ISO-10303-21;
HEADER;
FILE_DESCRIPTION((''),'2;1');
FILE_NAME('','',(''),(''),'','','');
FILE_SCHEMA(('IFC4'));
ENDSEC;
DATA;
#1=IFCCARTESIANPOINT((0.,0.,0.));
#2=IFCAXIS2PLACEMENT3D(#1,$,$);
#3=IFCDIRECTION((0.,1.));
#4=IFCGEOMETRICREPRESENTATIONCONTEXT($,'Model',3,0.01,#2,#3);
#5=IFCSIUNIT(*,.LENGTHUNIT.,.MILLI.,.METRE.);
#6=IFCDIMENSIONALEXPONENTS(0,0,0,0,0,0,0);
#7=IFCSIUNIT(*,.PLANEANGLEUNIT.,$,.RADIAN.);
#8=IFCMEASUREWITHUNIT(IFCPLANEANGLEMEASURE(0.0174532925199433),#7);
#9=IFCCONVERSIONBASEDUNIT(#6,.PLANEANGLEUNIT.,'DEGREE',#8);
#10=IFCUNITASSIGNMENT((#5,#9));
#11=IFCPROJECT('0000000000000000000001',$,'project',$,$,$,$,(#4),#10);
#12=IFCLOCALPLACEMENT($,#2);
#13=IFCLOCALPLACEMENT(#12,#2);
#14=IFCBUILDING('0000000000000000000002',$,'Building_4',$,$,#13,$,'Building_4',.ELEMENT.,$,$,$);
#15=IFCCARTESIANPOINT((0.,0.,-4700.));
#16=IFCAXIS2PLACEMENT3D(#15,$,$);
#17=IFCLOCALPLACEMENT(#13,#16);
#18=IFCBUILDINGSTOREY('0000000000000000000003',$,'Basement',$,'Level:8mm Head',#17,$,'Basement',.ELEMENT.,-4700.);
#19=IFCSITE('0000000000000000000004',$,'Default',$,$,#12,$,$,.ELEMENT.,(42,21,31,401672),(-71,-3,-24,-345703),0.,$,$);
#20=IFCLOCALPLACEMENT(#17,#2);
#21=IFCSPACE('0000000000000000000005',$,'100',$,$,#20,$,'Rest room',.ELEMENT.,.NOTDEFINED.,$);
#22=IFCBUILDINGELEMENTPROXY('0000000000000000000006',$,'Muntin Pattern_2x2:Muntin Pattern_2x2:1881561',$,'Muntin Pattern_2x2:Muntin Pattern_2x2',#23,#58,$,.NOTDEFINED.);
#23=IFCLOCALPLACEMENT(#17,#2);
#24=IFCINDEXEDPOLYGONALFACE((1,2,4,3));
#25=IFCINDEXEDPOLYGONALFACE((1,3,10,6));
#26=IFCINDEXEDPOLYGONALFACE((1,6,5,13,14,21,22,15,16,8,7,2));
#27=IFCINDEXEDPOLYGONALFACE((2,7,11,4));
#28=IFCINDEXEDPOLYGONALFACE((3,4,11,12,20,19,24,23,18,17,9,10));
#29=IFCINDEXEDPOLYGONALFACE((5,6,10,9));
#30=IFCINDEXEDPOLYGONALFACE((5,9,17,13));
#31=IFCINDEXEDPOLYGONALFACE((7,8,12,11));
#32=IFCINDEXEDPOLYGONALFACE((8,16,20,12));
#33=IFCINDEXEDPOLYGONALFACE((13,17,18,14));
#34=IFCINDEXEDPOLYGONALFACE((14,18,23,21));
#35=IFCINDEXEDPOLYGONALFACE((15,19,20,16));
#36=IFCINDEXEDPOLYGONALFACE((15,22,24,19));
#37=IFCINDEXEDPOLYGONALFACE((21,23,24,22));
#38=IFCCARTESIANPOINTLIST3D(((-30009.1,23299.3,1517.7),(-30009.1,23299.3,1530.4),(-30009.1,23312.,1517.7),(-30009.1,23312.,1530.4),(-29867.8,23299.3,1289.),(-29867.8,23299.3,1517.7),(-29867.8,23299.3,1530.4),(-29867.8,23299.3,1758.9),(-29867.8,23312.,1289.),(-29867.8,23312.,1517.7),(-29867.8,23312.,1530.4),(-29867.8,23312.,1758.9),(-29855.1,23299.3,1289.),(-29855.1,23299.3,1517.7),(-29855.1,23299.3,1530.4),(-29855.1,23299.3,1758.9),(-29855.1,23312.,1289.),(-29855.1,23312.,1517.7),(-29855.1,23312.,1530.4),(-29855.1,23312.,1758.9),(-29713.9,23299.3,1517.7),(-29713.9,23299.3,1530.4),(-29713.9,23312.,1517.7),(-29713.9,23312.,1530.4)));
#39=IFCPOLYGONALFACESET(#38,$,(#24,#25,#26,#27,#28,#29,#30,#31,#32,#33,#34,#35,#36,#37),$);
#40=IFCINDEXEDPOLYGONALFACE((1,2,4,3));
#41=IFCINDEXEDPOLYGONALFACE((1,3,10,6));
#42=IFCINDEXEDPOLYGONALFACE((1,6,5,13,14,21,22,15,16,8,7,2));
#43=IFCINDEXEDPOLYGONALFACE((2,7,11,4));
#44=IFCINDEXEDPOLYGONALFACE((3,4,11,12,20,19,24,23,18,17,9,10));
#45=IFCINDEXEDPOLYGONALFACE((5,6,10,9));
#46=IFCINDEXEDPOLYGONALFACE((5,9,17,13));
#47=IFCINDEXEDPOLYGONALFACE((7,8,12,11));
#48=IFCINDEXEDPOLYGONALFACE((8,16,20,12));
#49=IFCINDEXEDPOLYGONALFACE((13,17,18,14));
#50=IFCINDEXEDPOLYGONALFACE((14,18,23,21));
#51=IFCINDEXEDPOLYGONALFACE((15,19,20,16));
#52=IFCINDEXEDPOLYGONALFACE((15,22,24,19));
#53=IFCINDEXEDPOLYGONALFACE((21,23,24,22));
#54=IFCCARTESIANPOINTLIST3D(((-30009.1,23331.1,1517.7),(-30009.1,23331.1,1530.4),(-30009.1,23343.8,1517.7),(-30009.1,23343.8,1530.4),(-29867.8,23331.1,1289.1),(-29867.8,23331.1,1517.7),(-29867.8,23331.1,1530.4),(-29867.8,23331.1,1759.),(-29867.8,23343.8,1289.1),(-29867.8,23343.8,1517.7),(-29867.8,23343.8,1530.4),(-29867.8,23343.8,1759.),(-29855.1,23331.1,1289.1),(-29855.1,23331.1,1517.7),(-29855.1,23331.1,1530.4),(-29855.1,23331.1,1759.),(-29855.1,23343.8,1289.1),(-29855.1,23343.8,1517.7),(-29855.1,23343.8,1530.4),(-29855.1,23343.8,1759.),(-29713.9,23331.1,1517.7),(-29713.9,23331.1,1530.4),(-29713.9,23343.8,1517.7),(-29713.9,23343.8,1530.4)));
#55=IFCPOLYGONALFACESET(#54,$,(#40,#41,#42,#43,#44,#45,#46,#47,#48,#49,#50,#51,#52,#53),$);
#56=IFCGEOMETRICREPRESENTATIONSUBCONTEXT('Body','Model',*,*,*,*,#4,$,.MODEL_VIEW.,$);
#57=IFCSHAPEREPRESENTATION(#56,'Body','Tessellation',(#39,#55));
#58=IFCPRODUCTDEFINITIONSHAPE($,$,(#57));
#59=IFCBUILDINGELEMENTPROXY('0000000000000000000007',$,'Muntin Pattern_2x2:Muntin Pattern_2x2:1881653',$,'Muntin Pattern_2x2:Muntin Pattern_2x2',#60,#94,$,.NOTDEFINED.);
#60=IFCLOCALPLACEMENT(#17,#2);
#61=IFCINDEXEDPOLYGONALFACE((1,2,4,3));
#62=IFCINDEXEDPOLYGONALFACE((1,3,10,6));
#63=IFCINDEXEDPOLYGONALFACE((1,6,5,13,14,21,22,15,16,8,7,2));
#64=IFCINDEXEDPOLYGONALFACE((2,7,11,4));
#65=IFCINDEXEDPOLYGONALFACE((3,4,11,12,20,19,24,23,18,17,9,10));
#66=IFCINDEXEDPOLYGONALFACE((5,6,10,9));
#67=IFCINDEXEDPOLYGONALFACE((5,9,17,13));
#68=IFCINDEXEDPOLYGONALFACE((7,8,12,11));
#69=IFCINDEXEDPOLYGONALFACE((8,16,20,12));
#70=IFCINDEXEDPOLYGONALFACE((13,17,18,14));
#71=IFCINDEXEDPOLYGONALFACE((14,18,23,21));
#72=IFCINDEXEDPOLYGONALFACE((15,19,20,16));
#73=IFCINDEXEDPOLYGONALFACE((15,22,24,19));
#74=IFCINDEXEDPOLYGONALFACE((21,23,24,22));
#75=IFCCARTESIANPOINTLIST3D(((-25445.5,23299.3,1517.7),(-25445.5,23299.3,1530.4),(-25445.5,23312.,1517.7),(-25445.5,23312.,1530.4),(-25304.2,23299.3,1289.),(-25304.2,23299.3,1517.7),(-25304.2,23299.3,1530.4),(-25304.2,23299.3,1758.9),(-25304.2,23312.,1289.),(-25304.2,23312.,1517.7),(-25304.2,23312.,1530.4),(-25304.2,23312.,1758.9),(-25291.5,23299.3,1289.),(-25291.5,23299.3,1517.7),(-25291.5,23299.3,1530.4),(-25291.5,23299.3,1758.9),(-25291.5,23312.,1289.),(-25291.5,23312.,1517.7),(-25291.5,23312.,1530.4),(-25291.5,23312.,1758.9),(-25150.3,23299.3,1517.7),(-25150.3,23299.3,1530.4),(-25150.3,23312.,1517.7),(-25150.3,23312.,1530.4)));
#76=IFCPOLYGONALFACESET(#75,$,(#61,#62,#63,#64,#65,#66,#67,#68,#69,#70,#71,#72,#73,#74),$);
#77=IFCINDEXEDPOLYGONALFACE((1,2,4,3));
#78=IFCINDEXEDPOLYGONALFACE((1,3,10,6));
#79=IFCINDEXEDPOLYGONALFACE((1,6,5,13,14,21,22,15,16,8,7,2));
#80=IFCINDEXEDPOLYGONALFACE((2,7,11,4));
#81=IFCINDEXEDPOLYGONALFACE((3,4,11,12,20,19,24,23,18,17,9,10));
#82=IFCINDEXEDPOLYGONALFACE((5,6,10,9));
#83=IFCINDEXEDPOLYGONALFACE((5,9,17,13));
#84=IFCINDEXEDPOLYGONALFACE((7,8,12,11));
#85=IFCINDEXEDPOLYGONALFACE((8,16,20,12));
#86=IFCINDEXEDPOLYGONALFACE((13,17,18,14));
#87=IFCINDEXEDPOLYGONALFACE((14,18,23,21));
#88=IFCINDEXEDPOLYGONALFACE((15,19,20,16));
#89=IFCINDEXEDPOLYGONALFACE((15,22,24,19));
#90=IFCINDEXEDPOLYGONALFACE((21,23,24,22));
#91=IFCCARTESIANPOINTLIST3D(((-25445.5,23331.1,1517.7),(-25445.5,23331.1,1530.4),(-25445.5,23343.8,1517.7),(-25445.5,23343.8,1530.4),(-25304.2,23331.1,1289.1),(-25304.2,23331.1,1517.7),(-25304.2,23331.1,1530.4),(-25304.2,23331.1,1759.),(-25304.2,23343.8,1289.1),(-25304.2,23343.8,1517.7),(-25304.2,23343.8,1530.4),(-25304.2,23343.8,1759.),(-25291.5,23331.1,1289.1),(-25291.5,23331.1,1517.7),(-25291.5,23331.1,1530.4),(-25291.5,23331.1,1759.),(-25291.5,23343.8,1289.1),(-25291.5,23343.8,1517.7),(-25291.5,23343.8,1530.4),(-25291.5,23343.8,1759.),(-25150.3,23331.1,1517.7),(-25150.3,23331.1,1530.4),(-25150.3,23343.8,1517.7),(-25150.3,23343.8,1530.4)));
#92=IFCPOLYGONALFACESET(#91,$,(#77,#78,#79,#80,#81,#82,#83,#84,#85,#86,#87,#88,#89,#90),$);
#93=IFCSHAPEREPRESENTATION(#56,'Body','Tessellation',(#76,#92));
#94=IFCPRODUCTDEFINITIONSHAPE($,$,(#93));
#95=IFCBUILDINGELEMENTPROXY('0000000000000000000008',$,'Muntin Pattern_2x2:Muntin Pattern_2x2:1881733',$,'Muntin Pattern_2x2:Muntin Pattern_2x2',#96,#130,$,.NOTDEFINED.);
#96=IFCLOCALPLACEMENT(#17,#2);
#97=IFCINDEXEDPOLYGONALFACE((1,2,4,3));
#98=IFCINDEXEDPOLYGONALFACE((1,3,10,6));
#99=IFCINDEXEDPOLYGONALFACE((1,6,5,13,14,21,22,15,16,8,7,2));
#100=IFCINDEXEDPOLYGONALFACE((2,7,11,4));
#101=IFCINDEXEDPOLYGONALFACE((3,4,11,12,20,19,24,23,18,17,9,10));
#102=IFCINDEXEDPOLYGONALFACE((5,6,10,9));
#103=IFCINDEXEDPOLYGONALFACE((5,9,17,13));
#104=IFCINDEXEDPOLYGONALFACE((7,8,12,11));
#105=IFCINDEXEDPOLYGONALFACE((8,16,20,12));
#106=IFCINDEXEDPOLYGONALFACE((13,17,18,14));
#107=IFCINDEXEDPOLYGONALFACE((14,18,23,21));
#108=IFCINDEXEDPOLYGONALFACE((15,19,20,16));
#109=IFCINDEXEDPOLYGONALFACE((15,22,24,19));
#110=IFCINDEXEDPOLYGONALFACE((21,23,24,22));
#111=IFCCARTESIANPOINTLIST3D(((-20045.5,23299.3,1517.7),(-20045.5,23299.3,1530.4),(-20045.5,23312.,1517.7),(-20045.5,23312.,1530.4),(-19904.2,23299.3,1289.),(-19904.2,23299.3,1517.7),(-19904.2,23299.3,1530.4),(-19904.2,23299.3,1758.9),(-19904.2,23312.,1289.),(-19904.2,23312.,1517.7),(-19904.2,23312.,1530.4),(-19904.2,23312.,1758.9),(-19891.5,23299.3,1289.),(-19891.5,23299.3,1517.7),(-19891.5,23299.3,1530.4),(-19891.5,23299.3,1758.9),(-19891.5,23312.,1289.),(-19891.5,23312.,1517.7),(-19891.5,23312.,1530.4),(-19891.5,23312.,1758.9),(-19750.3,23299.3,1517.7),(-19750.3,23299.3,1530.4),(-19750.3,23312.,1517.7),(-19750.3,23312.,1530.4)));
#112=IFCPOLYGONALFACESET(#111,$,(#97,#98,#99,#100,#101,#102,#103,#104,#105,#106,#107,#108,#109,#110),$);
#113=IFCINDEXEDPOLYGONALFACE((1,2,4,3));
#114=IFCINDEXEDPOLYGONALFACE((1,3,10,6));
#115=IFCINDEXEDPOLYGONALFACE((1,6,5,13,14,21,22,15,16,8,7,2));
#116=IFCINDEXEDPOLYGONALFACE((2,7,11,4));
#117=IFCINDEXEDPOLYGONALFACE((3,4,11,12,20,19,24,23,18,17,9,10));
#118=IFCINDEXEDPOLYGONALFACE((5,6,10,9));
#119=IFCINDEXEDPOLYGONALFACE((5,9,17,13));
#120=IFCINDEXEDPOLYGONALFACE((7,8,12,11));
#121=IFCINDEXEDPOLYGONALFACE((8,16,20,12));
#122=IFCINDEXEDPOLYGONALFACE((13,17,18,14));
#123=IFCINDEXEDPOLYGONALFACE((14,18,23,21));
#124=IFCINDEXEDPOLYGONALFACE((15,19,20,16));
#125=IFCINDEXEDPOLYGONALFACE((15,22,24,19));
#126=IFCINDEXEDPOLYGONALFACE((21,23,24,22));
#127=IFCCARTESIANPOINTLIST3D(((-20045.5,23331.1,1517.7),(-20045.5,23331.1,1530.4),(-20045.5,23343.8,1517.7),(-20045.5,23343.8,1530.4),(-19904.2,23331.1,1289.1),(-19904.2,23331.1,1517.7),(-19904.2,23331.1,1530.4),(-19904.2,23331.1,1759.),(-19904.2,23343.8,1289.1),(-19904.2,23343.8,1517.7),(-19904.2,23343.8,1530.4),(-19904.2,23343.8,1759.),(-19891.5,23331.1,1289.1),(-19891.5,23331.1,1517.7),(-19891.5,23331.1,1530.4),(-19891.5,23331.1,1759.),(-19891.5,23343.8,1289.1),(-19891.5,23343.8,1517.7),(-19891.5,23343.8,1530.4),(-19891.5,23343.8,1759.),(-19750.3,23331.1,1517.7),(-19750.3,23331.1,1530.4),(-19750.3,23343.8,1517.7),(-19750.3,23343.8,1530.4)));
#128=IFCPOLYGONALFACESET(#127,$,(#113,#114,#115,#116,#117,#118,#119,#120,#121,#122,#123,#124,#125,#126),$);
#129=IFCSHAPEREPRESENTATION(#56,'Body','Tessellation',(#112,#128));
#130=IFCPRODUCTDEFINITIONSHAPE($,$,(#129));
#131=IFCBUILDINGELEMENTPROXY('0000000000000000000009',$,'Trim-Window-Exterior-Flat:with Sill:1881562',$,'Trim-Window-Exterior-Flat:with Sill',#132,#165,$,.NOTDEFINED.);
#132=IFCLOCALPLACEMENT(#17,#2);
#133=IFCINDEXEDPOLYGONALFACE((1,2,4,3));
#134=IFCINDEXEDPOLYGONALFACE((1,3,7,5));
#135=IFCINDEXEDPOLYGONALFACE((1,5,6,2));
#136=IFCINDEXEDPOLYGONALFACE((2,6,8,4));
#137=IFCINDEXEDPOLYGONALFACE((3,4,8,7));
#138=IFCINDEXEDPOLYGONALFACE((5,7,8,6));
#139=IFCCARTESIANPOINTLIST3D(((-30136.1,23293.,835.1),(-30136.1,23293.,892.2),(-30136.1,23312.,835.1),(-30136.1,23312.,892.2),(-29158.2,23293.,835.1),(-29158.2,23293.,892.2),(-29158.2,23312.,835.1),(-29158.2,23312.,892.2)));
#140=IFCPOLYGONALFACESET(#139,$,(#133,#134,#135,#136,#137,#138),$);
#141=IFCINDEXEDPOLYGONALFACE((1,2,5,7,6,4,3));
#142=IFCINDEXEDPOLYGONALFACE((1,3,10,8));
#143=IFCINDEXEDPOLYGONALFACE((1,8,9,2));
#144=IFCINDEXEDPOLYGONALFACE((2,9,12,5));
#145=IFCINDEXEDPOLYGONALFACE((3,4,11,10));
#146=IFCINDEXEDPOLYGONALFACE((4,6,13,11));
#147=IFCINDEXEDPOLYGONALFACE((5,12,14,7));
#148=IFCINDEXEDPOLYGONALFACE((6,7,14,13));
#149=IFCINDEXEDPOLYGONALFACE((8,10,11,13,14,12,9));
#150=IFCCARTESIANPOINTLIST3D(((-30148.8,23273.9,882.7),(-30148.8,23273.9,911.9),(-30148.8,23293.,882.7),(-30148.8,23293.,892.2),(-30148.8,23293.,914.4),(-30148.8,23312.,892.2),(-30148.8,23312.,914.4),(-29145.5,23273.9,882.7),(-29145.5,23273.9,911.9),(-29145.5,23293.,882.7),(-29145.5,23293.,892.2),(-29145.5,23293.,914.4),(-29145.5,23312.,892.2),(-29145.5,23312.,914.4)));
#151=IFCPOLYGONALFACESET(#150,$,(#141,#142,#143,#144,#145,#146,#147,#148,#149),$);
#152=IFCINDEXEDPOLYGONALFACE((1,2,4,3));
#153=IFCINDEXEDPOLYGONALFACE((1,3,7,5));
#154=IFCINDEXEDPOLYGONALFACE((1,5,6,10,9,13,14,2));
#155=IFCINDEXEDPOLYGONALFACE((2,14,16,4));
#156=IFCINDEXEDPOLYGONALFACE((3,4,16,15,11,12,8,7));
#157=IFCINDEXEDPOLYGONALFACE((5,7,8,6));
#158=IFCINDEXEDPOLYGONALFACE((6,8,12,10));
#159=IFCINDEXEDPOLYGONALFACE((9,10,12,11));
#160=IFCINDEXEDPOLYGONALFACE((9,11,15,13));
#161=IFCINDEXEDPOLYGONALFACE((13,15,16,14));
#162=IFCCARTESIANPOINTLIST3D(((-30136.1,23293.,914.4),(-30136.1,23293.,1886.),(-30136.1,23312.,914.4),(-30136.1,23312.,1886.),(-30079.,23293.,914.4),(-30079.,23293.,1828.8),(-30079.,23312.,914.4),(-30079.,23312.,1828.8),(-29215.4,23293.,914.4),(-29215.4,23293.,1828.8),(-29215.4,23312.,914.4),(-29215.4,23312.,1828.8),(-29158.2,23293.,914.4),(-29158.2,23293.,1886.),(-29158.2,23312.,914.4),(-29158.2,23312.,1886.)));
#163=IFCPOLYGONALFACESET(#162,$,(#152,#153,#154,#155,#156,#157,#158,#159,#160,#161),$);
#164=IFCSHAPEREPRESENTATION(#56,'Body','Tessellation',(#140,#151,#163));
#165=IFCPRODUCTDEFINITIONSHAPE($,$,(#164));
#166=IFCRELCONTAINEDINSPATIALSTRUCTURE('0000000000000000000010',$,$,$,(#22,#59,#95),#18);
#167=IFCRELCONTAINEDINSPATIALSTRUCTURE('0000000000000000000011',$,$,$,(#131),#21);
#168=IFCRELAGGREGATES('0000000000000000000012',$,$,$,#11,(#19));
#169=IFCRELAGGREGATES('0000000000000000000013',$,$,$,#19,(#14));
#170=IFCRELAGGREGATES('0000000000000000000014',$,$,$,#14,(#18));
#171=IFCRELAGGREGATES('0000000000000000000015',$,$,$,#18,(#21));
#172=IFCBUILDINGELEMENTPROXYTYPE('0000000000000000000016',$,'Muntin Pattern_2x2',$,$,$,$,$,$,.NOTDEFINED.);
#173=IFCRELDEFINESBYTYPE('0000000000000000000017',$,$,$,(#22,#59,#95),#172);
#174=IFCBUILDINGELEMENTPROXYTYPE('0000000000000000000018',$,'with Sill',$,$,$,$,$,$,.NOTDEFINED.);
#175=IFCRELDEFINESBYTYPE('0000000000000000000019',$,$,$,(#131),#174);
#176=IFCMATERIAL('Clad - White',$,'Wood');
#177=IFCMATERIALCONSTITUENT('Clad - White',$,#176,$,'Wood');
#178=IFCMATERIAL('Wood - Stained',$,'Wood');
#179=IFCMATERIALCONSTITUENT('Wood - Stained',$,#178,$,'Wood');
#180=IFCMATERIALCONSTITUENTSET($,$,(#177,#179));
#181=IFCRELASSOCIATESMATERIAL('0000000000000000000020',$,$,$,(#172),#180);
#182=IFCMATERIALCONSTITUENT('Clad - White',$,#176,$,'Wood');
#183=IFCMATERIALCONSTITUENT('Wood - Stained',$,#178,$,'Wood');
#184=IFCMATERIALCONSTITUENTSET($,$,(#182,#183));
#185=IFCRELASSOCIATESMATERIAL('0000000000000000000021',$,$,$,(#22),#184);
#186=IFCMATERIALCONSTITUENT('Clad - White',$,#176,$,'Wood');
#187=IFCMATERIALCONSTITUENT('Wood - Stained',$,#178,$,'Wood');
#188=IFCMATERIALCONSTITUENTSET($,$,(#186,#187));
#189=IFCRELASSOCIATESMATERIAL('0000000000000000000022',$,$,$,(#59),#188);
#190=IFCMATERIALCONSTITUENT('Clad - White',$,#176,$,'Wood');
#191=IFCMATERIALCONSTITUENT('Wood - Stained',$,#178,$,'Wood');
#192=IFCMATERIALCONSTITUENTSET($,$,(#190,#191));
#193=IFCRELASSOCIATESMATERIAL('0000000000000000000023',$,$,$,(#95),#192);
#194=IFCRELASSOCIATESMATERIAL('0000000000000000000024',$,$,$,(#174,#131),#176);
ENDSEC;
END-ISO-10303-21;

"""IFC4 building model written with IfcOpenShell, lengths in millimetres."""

from ifc_helpers import new_model, entity, si_unit, converted_unit, direction, frame, origin, place, context, subcontext, project, spatial, indexed_curve, outline, extrude, source, transform, mapped, material, constituent, constituent_set, type_object, type_shapes, element, save


model = new_model("IFC4")

# Units and contexts
model_context = context("Model", 3, precision=0.01, world=origin(), true_north=direction((0.0, 1.0)))
body_context = subcontext(model_context, "Body", "Model", "MODEL_VIEW")
ifc_project = project(units=[si_unit("LENGTHUNIT", "METRE", prefix="MILLI"), converted_unit("PLANEANGLEUNIT", "DEGREE", entity("IfcPlaneAngleMeasure", 0.0174532925199433), si_unit("PLANEANGLEUNIT", "RADIAN"), dimensions=[0, 0, 0, 0, 0, 0, 0])], contexts=[model_context])

# Site, building, storey
site_placement = place(None, origin())
site = spatial("IfcSite", under=ifc_project, at=site_placement, Name="Default", CompositionType="ELEMENT", RefLatitude=(42, 21, 31, 401672), RefLongitude=(-71, -3, -24, -345703), RefElevation=0.0)
building_placement = place(site_placement, origin())
building = spatial("IfcBuilding", under=site, at=building_placement, Name="Building_4", LongName="Building_4", CompositionType="ELEMENT")
storey_placement = place(building_placement, frame((0.0, 0.0, -4700.0)))
storey = spatial("IfcBuildingStorey", under=building, at=storey_placement, Name="Basement", ObjectType="Level:8mm Head", LongName="Basement", CompositionType="ELEMENT", Elevation=-4700.0)

# Building element proxies
ifc_material_1 = material(Name="Clad - White", Category="Wood")
ifc_material_2 = material(Name="Wood - Stained", Category="Wood")
ifc_constituent_1 = constituent(ifc_material_1, Name="Clad - White", Category="Wood")
ifc_constituent_2 = constituent(ifc_material_2, Name="Wood - Stained", Category="Wood")
ifc_constituent_set_1 = constituent_set(constituents=[ifc_constituent_1, ifc_constituent_2])
ifc_constituent_3 = constituent(ifc_material_1, Name="Clad - White", Category="Wood")
ifc_constituent_4 = constituent(ifc_material_2, Name="Wood - Stained", Category="Wood")
ifc_constituent_set_2 = constituent_set(constituents=[ifc_constituent_3, ifc_constituent_4])
building_element_proxy_type_1 = type_object("IfcBuildingElementProxyType", Name="Muntin Pattern_2x2", PredefinedType="NOTDEFINED", material=ifc_constituent_set_2)
shared_shape_1 = source(origin(), body_context, "Body", "SweptSolid", [
    extrude(outline(indexed_curve([(6.4, -6.4), (234.9, -6.4), (234.9, 6.3), (6.4, 6.3), (6.4, 147.6), (-6.3, 147.6), (-6.3, 6.3), (-235.0, 6.3), (-235.0, -6.4), (-6.3, -6.4), (-6.3, -147.6), (6.4, -147.6), (6.4, -6.4)], self_intersect=False)), frame((0.0, -22.2, 234.9), z_axis=(0.0, 1.0, 0.0), x_axis=(0.0, 0.0, 1.0)), (0.0, 0.0, 1.0), 12.7),
    extrude(outline(indexed_curve([(6.4, -6.4), (235.0, -6.4), (235.0, 6.3), (6.4, 6.3), (6.4, 147.6), (-6.3, 147.6), (-6.3, 6.3), (-235.0, 6.3), (-235.0, -6.4), (-6.3, -6.4), (-6.3, -147.6), (6.4, -147.6), (6.4, -6.4)], self_intersect=False)), frame((0.0, 9.5, 235.0), z_axis=(0.0, 1.0, 0.0), x_axis=(0.0, 0.0, 1.0)), (0.0, 0.0, 1.0), 12.7),
])
type_shapes(building_element_proxy_type_1, [shared_shape_1])
proxy_1_placement = place(storey_placement, frame((-29861.5, 23321.5, 1289.1)))
element("IfcBuildingElementProxy", 1, at=proxy_1_placement, inside=storey, type_object=building_element_proxy_type_1, material=ifc_constituent_set_1, Name="Muntin Pattern_2x2:Muntin Pattern_2x2:1881561", ObjectType="Muntin Pattern_2x2:Muntin Pattern_2x2", PredefinedType="NOTDEFINED", context=body_context, shape_type="MappedRepresentation", body=[
    mapped(shared_shape_1, transform((0.0, 0.0, 0.0), scale=1.0)),
])
ifc_constituent_5 = constituent(ifc_material_1, Name="Clad - White", Category="Wood")
ifc_constituent_6 = constituent(ifc_material_2, Name="Wood - Stained", Category="Wood")
ifc_constituent_set_3 = constituent_set(constituents=[ifc_constituent_5, ifc_constituent_6])
proxy_2_placement = place(storey_placement, frame((-25297.9, 23321.5, 1289.1)))
element("IfcBuildingElementProxy", 2, at=proxy_2_placement, inside=storey, type_object=building_element_proxy_type_1, material=ifc_constituent_set_3, Name="Muntin Pattern_2x2:Muntin Pattern_2x2:1881653", ObjectType="Muntin Pattern_2x2:Muntin Pattern_2x2", PredefinedType="NOTDEFINED", context=body_context, shape_type="MappedRepresentation", body=[
    mapped(shared_shape_1, transform((0.0, 0.0, 0.0), scale=1.0)),
])
ifc_constituent_7 = constituent(ifc_material_1, Name="Clad - White", Category="Wood")
ifc_constituent_8 = constituent(ifc_material_2, Name="Wood - Stained", Category="Wood")
ifc_constituent_set_4 = constituent_set(constituents=[ifc_constituent_7, ifc_constituent_8])
proxy_3_placement = place(storey_placement, frame((-19897.9, 23321.5, 1289.1)))
element("IfcBuildingElementProxy", 3, at=proxy_3_placement, inside=storey, type_object=building_element_proxy_type_1, material=ifc_constituent_set_4, Name="Muntin Pattern_2x2:Muntin Pattern_2x2:1881733", ObjectType="Muntin Pattern_2x2:Muntin Pattern_2x2", PredefinedType="NOTDEFINED", context=body_context, shape_type="MappedRepresentation", body=[
    mapped(shared_shape_1, transform((0.0, 0.0, 0.0), scale=1.0)),
])

# Shared definitions
space_1_placement = place(storey_placement, origin())
space_1 = spatial("IfcSpace", under=storey, at=space_1_placement, Name="100", LongName="Rest room", CompositionType="ELEMENT", PredefinedType="NOTDEFINED")

# Building element proxy
building_element_proxy_type_2 = type_object("IfcBuildingElementProxyType", Name="with Sill", PredefinedType="NOTDEFINED", material=ifc_material_1)
shared_shape_2 = source(origin(), body_context, "Body", "SweptSolid", [
    extrude(outline(indexed_curve([(-488.9, -28.6), (488.9, -28.6), (488.9, 28.6), (-488.9, 28.6), (-488.9, -28.6)], self_intersect=False)), frame((0.0, -965.2, 0.0), z_axis=(0.0, 0.0, 1.0), x_axis=(-1.0, 0.0, 0.0)), (0.0, 0.0, 1.0), 19.1),
    extrude(outline(indexed_curve([(-19.0, -16.0), (0.0, -16.0), (0.0, -6.4), (19.0, -6.4), (19.0, 15.8), (0.0, 15.8), (-19.0, 13.3), (-19.0, -16.0)], self_intersect=False)), frame((-501.6, -930.2, 19.0), z_axis=(1.0, 0.0, 0.0), x_axis=(0.0, 0.0, -1.0)), (0.0, 0.0, 1.0), 1003.3),
    extrude(outline(indexed_curve([(-500.1, -488.9), (471.5, -488.9), (471.5, -431.8), (-442.9, -431.8), (-442.9, 431.8), (471.5, 431.8), (471.5, 488.9), (-500.1, 488.9), (-500.1, -488.9)], self_intersect=False)), frame((0.0, -442.9, 0.0), z_axis=(0.0, 0.0, 1.0), x_axis=(0.0, -1.0, 0.0)), (0.0, 0.0, 1.0), 19.1),
])
type_shapes(building_element_proxy_type_2, [shared_shape_2])
proxy_4_placement = place(space_1_placement, frame((-29647.2, 23312.0, 1828.8), z_axis=(0.0, -1.0, 0.0), x_axis=(1.0, 0.0, 0.0)))
element("IfcBuildingElementProxy", 4, at=proxy_4_placement, inside=space_1, type_object=building_element_proxy_type_2, material=ifc_material_1, Name="Trim-Window-Exterior-Flat:with Sill:1881562", ObjectType="Trim-Window-Exterior-Flat:with Sill", PredefinedType="NOTDEFINED", context=body_context, shape_type="MappedRepresentation", body=[
    mapped(shared_shape_2, transform((0.0, 0.0, 0.0), scale=1.0)),
])

save(model, "model.ifc")
